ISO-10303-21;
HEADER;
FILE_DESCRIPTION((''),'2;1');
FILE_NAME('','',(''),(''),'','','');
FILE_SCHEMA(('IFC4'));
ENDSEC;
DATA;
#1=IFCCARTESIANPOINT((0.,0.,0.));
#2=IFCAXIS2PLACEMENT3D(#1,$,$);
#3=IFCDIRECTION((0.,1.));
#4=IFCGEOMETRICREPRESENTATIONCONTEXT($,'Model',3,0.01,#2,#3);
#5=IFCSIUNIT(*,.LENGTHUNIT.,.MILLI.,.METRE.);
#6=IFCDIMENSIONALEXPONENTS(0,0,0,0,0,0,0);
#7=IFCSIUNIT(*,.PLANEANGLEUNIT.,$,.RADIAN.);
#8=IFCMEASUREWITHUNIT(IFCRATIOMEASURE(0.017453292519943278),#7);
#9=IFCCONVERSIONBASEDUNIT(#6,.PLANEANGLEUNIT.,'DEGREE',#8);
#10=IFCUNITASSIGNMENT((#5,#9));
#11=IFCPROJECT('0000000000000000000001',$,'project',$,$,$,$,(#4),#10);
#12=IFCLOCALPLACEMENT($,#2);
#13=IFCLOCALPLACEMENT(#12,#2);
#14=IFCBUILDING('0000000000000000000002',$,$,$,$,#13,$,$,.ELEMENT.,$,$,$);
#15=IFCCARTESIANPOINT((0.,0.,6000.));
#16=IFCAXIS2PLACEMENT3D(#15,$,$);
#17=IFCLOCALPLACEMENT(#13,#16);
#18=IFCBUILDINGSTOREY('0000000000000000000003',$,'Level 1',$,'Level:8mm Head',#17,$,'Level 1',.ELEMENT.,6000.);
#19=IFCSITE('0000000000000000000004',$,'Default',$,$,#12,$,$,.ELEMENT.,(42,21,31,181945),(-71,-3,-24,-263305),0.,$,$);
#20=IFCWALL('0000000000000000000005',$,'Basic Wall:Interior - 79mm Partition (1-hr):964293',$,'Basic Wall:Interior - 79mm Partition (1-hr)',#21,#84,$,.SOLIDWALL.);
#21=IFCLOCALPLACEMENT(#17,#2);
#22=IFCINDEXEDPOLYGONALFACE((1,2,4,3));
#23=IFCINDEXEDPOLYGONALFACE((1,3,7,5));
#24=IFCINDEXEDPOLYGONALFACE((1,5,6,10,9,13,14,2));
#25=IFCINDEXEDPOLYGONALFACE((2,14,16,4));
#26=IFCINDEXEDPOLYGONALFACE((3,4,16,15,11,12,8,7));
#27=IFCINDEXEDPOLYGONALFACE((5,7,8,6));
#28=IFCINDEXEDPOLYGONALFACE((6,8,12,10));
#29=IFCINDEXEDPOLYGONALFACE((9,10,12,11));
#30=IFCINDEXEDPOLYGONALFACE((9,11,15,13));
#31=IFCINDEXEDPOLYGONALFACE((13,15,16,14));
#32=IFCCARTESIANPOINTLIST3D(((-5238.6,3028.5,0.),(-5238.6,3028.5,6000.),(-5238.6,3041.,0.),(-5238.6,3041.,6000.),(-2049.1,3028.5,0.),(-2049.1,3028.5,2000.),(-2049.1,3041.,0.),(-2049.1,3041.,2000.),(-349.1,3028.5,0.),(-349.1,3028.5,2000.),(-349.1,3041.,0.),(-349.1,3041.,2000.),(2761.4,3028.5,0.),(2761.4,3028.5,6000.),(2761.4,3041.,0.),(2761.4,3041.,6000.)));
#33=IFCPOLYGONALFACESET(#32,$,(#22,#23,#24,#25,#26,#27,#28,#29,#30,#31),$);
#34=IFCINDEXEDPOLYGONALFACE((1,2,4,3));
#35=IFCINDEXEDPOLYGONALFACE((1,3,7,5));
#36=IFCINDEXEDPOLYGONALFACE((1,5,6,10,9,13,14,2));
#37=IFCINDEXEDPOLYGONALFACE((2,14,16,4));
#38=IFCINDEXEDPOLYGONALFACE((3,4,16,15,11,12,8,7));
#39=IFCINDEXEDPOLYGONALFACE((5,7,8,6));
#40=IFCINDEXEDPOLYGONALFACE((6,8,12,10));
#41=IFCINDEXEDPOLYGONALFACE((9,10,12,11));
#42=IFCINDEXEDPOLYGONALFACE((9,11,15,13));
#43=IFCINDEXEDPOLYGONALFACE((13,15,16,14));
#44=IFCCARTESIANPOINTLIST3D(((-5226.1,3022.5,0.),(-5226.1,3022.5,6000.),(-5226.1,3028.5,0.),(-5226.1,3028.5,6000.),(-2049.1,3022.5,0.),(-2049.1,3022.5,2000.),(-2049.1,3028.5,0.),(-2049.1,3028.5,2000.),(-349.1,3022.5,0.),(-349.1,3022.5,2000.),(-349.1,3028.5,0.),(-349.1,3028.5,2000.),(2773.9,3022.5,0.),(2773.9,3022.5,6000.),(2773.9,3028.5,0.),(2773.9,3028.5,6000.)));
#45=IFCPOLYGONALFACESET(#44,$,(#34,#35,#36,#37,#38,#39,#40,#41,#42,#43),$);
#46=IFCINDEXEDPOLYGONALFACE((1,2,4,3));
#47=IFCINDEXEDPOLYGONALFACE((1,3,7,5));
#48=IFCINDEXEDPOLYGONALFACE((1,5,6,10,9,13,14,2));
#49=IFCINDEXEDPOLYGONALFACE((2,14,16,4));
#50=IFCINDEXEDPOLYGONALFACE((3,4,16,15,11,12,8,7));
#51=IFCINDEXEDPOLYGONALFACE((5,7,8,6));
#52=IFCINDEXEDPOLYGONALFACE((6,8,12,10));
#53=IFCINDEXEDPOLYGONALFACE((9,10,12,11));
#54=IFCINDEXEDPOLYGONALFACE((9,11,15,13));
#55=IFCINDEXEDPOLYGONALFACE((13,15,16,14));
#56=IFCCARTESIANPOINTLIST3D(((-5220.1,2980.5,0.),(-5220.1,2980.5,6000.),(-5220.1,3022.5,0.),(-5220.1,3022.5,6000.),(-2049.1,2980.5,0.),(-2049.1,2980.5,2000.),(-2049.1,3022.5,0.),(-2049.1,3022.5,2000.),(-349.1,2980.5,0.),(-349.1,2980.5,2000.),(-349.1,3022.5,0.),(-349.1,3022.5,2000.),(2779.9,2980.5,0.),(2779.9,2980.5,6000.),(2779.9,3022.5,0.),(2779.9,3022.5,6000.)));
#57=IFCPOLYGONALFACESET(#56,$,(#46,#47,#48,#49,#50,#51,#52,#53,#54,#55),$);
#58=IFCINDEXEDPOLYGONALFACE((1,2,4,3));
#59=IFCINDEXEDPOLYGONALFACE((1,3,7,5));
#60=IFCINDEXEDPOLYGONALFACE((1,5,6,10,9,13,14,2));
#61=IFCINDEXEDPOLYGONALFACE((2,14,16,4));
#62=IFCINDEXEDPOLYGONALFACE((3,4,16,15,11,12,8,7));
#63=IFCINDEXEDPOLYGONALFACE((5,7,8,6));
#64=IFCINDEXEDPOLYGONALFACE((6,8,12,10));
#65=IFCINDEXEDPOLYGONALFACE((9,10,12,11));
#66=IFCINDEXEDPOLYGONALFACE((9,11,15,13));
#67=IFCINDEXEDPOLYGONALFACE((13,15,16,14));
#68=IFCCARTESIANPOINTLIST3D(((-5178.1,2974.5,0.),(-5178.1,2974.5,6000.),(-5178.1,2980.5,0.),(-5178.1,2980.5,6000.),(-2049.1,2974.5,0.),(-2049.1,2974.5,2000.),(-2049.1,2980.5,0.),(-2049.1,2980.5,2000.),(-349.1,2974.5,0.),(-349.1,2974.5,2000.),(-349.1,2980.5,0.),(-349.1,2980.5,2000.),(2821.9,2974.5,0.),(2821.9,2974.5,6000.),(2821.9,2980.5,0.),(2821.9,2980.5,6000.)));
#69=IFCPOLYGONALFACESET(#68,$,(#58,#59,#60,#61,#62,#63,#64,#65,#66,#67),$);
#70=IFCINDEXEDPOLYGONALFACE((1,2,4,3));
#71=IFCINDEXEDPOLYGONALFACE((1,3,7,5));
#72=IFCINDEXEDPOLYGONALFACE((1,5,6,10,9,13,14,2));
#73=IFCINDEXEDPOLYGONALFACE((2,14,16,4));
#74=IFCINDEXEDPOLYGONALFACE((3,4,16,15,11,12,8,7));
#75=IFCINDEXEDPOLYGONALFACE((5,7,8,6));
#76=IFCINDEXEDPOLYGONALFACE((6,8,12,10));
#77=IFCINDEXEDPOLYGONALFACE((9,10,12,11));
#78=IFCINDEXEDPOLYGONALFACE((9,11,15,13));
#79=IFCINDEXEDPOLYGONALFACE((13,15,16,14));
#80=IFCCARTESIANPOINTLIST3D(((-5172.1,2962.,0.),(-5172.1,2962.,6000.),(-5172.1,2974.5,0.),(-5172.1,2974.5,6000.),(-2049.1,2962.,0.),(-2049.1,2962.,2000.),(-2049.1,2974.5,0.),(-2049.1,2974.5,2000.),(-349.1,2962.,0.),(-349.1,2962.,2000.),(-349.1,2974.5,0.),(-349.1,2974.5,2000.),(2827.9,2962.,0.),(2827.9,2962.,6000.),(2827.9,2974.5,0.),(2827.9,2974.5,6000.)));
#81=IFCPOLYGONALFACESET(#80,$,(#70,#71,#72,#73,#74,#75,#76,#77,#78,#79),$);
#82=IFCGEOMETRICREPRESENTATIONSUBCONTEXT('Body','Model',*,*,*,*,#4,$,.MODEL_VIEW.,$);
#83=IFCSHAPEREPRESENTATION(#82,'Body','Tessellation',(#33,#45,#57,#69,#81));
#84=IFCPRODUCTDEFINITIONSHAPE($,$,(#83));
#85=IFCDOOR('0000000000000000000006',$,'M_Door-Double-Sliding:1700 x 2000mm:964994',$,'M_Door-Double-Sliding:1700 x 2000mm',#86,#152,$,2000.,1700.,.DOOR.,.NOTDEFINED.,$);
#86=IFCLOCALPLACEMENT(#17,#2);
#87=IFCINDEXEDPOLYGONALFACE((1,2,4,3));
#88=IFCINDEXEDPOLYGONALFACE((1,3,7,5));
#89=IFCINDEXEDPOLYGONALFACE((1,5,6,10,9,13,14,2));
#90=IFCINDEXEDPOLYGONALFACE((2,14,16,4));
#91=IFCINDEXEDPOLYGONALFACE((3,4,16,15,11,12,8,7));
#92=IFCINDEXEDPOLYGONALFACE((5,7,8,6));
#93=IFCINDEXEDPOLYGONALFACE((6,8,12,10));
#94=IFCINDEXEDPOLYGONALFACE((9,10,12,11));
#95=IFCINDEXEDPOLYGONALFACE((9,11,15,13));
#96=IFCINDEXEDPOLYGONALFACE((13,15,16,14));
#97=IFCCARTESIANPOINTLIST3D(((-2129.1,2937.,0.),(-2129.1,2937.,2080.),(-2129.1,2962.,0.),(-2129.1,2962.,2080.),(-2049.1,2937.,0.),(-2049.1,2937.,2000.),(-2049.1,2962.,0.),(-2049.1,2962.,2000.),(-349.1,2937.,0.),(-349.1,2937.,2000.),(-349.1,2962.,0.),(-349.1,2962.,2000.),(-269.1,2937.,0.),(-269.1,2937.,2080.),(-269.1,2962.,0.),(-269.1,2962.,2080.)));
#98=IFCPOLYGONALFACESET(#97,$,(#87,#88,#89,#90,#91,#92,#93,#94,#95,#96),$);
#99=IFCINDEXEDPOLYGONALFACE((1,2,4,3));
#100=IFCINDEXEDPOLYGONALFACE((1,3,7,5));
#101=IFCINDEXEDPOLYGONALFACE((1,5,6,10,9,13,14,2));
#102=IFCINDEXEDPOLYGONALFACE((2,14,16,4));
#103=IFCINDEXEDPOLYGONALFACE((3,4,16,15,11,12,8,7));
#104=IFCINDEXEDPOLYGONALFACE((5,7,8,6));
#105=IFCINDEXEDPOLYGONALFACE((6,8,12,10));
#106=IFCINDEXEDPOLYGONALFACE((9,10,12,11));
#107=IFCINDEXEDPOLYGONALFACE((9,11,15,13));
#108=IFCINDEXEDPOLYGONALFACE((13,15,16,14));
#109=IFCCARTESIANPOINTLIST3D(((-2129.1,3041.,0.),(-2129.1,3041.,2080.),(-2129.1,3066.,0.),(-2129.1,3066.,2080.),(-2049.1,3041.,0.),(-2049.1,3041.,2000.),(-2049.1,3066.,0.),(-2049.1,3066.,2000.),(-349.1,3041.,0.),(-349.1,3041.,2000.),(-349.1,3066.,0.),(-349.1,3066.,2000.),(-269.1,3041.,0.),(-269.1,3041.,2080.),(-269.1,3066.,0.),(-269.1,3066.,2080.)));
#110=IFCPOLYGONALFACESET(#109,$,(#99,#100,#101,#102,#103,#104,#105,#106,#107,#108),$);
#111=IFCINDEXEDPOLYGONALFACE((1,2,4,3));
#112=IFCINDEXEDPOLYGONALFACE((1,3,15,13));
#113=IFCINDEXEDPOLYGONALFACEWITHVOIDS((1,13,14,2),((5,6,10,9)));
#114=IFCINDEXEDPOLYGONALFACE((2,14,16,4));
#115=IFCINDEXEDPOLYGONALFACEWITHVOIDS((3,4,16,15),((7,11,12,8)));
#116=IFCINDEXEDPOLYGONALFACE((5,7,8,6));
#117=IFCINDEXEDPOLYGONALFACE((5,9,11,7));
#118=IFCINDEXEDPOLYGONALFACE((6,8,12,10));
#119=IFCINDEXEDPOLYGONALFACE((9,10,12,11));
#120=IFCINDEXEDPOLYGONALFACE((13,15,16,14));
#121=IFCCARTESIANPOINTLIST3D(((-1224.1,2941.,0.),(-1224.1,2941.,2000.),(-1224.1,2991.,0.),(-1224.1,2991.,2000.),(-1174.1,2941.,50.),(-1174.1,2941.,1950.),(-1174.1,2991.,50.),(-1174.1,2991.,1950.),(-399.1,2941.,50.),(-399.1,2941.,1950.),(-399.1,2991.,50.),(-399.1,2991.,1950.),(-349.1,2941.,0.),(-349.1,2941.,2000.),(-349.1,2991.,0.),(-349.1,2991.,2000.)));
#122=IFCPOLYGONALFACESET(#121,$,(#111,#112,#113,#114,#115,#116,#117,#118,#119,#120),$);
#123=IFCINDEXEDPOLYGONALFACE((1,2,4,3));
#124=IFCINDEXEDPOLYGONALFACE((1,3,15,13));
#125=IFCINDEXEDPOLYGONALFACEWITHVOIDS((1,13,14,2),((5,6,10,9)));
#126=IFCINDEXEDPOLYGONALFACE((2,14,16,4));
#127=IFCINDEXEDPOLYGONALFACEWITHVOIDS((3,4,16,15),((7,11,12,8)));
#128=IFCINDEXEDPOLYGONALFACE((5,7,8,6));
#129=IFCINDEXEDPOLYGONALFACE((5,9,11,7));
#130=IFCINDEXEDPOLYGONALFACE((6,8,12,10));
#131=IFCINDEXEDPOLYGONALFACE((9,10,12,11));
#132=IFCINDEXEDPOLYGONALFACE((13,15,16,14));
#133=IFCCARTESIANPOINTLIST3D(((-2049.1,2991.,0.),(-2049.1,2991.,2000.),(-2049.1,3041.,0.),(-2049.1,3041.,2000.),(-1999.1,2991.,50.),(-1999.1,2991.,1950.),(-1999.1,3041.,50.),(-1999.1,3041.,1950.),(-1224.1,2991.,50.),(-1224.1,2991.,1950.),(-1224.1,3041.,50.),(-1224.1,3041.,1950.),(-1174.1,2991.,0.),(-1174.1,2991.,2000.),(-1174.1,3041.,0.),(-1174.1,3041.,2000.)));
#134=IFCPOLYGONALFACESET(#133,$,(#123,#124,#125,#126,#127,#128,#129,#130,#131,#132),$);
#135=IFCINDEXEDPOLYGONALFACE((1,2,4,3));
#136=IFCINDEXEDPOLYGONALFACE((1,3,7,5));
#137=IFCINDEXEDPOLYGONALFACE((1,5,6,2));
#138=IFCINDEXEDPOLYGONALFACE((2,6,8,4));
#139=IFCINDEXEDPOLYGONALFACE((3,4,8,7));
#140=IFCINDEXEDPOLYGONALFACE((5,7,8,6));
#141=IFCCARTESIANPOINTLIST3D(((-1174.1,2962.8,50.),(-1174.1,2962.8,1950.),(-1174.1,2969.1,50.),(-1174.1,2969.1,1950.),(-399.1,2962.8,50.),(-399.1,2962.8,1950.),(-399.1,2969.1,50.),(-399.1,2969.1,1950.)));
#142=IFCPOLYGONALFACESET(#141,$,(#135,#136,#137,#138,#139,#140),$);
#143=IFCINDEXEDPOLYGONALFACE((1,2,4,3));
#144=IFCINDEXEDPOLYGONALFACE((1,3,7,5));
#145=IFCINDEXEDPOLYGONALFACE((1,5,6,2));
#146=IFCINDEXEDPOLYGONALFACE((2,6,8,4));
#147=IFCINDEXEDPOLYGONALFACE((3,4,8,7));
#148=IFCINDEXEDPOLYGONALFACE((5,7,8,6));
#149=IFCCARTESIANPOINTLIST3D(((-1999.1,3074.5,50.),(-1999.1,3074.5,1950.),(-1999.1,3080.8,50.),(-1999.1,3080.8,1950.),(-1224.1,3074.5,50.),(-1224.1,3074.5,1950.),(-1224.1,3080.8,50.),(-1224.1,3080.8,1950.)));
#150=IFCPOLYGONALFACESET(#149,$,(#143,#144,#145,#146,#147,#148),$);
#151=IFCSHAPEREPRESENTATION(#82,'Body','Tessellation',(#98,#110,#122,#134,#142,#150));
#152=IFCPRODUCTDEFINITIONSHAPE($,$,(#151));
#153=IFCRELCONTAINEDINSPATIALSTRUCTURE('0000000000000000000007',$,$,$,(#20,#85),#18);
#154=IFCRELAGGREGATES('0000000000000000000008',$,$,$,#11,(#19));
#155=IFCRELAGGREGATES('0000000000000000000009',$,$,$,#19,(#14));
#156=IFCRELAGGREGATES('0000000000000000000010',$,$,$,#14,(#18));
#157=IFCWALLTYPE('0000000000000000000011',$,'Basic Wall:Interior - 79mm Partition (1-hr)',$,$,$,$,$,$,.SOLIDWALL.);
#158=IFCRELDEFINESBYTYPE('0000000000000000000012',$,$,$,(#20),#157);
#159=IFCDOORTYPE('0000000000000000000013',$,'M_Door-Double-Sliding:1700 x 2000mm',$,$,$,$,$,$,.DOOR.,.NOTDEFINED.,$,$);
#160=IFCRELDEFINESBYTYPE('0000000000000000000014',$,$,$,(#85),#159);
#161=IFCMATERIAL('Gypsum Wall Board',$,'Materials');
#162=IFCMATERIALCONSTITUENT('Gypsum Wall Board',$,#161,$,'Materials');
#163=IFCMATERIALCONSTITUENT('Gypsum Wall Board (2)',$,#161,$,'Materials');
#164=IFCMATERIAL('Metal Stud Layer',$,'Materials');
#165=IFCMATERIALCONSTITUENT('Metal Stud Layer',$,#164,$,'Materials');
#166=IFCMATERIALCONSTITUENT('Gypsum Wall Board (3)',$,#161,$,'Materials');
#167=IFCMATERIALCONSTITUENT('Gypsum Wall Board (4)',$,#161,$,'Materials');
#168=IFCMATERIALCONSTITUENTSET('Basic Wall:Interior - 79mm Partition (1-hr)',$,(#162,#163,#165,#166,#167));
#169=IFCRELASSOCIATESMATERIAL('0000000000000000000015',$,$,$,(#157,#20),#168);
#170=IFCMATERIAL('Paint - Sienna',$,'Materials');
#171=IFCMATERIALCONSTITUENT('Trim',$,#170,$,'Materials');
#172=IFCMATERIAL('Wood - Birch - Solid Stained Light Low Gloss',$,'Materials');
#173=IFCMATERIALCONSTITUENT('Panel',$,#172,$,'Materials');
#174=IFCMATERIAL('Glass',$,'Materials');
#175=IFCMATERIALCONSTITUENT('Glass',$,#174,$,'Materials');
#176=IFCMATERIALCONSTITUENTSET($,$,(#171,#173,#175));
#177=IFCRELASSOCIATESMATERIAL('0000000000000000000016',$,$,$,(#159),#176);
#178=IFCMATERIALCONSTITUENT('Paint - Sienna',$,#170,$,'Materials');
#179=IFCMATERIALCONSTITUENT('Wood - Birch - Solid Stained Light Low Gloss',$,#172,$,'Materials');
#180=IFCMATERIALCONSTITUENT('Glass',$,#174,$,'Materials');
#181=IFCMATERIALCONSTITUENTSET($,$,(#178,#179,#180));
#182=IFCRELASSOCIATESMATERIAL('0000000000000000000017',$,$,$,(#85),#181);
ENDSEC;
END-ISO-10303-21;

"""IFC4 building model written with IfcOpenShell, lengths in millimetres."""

from ifc_helpers import new_model, entity, si_unit, converted_unit, direction, frame, origin, place, context, subcontext, project, spatial, indexed_curve, outline, extrude, source, transform, mapped, material, constituent, constituent_set, type_object, type_shapes, element, fill, save


model = new_model("IFC4")

# Units and contexts
model_context = context("Model", 3, precision=0.01, world=origin(), true_north=direction((0.0, 1.0)))
body_context = subcontext(model_context, "Body", "Model", "MODEL_VIEW")
ifc_project = project(units=[si_unit("LENGTHUNIT", "METRE", prefix="MILLI"), converted_unit("PLANEANGLEUNIT", "DEGREE", entity("IfcRatioMeasure", 0.017453292519943278), si_unit("PLANEANGLEUNIT", "RADIAN"), dimensions=[0, 0, 0, 0, 0, 0, 0])], contexts=[model_context])

# Site, building, storey
site_placement = place(None, origin())
site = spatial("IfcSite", under=ifc_project, at=site_placement, Name="Default", CompositionType="ELEMENT", RefLatitude=(42, 21, 31, 181945), RefLongitude=(-71, -3, -24, -263305), RefElevation=0.0)
building_placement = place(site_placement, origin())
building = spatial("IfcBuilding", under=site, at=building_placement, CompositionType="ELEMENT")
storey_placement = place(building_placement, frame((0.0, 0.0, 6000.0)))
storey = spatial("IfcBuildingStorey", under=building, at=storey_placement, Name="Level 1", ObjectType="Level:8mm Head", LongName="Level 1", CompositionType="ELEMENT", Elevation=6000.0)

# Shared definitions
ifc_material_1 = material(Name="Gypsum Wall Board", Category="Materials")
ifc_constituent_1 = constituent(ifc_material_1, Name="Gypsum Wall Board", Category="Materials")
ifc_constituent_2 = constituent(ifc_material_1, Name="Gypsum Wall Board (2)", Category="Materials")
ifc_material_2 = material(Name="Metal Stud Layer", Category="Materials")
ifc_constituent_3 = constituent(ifc_material_2, Name="Metal Stud Layer", Category="Materials")
ifc_constituent_4 = constituent(ifc_material_1, Name="Gypsum Wall Board (3)", Category="Materials")
ifc_constituent_5 = constituent(ifc_material_1, Name="Gypsum Wall Board (4)", Category="Materials")
ifc_constituent_set_1 = constituent_set(constituents=[ifc_constituent_1, ifc_constituent_2, ifc_constituent_3, ifc_constituent_4, ifc_constituent_5], Name="Basic Wall:Interior - 79mm Partition (1-hr)")
wall_type = type_object("IfcWallType", Name="Basic Wall:Interior - 79mm Partition (1-hr)", PredefinedType="SOLIDWALL", material=ifc_constituent_set_1)

# Wall, opening, door
wall_1_placement = place(storey_placement, frame((2761.4, 3001.5, 0.0), z_axis=(0.0, 0.0, 1.0), x_axis=(-1.0, 0.0, 0.0)))
wall_1 = element("IfcWall", 1, at=wall_1_placement, inside=storey, type_object=wall_type, material=ifc_constituent_set_1, Name="Basic Wall:Interior - 79mm Partition (1-hr):964293", ObjectType="Basic Wall:Interior - 79mm Partition (1-hr)", PredefinedType="SOLIDWALL", context=body_context, shape_type="SweptSolid", body=[
    extrude(outline(indexed_curve([(-2000.0, -869.8), (-2000.0, -3980.3), (4000.0, -3980.3), (4000.0, 4019.8), (-2000.0, 4019.8), (-2000.0, 830.2), (0.0, 830.2), (0.0, -869.8), (-2000.0, -869.8)], self_intersect=False)), frame((3980.3, -27.0, 2000.0), z_axis=(0.0, 1.0, 0.0), x_axis=(0.0, 0.0, 1.0)), (0.0, 0.0, -1.0), 12.5),
    extrude(outline(indexed_curve([(-2000.0, -863.5), (-2000.0, -3986.5), (4000.0, -3986.5), (4000.0, 4013.5), (-2000.0, 4013.5), (-2000.0, 836.5), (0.0, 836.5), (0.0, -863.5), (-2000.0, -863.5)], self_intersect=False)), frame((3974.0, -21.0, 2000.0), z_axis=(0.0, 1.0, 0.0), x_axis=(0.0, 0.0, 1.0)), (0.0, 0.0, -1.0), 6.0),
    extrude(outline(indexed_curve([(-2000.0, -860.5), (-2000.0, -3989.5), (4000.0, -3989.5), (4000.0, 4010.5), (-2000.0, 4010.5), (-2000.0, 839.5), (0.0, 839.5), (0.0, -860.5), (-2000.0, -860.5)], self_intersect=False)), frame((3971.0, 21.0, 2000.0), z_axis=(0.0, 1.0, 0.0), x_axis=(0.0, 0.0, 1.0)), (0.0, 0.0, -1.0), 42.0),
    extrude(outline(indexed_curve([(-2000.0, -839.5), (-2000.0, -4010.5), (4000.0, -4010.5), (4000.0, 3989.5), (-2000.0, 3989.5), (-2000.0, 860.5), (0.0, 860.5), (0.0, -839.5), (-2000.0, -839.5)], self_intersect=False)), frame((3950.0, 27.0, 2000.0), z_axis=(0.0, 1.0, 0.0), x_axis=(0.0, 0.0, 1.0)), (0.0, 0.0, -1.0), 6.0),
    extrude(outline(indexed_curve([(-1631.3, 200.0), (-1631.3, 2200.0), (-4808.3, 2200.0), (-4808.3, -3800.0), (3179.2, -3800.0), (3191.7, -3800.0), (3191.7, 2200.0), (3179.2, 2200.0), (68.7, 2200.0), (68.7, 200.0), (-1631.3, 200.0)], self_intersect=False)), frame((4741.8, 39.5, 2200.0), z_axis=(0.0, 1.0, 0.0), x_axis=(1.0, 0.0, 0.0)), (0.0, 0.0, -1.0), 12.5),
])
opening_1_placement = place(wall_1_placement, frame((4810.5, 39.5, 0.0)))
opening_1 = element("IfcOpeningElement", 2, at=opening_1_placement, cuts=wall_1, PredefinedType="OPENING", context=body_context, shape_type="SweptSolid", body=[
    extrude(outline(indexed_curve([(2000.0, 0.0), (2000.0, 1700.0), (0.0, 1700.0), (0.0, 0.0), (2000.0, 0.0)], self_intersect=False)), frame((0.0, 0.0, 0.0), z_axis=(0.0, -1.0, 0.0), x_axis=(0.0, 0.0, 1.0)), (0.0, 0.0, 1.0), 79.0),
])
ifc_material_3 = material(Name="Paint - Sienna", Category="Materials")
ifc_constituent_6 = constituent(ifc_material_3, Name="Paint - Sienna", Category="Materials")
ifc_material_4 = material(Name="Wood - Birch - Solid Stained Light Low Gloss", Category="Materials")
ifc_constituent_7 = constituent(ifc_material_4, Name="Wood - Birch - Solid Stained Light Low Gloss", Category="Materials")
ifc_material_5 = material(Name="Glass", Category="Materials")
ifc_constituent_8 = constituent(ifc_material_5, Name="Glass", Category="Materials")
ifc_constituent_set_2 = constituent_set(constituents=[ifc_constituent_6, ifc_constituent_7, ifc_constituent_8])
ifc_constituent_9 = constituent(ifc_material_3, Name="Trim", Category="Materials")
ifc_constituent_10 = constituent(ifc_material_4, Name="Panel", Category="Materials")
ifc_constituent_11 = constituent(ifc_material_5, Name="Glass", Category="Materials")
ifc_constituent_set_3 = constituent_set(constituents=[ifc_constituent_9, ifc_constituent_10, ifc_constituent_11])
door_type = type_object("IfcDoorType", Name="M_Door-Double-Sliding:1700 x 2000mm", OperationType="NOTDEFINED", PredefinedType="DOOR", material=ifc_constituent_set_3)
shared_shape_1 = source(origin(), body_context, "Body", "SweptSolid", [
    extrude(outline(indexed_curve([(-1020.0, -930.0), (1060.0, -930.0), (1060.0, 930.0), (-1020.0, 930.0), (-1020.0, 850.0), (980.0, 850.0), (980.0, -850.0), (-1020.0, -850.0), (-1020.0, -930.0)], self_intersect=False)), frame((850.0, -25.0, 1020.0), z_axis=(0.0, 1.0, 0.0), x_axis=(0.0, 0.0, 1.0)), (0.0, 0.0, 1.0), 25.0),
    extrude(outline(indexed_curve([(-930.0, -1020.0), (-850.0, -1020.0), (-850.0, 980.0), (850.0, 980.0), (850.0, -1020.0), (930.0, -1020.0), (930.0, 1060.0), (-930.0, 1060.0), (-930.0, -1020.0)], self_intersect=False)), frame((850.0, 79.0, 1020.0), z_axis=(0.0, 1.0, 0.0), x_axis=(-1.0, 0.0, 0.0)), (0.0, 0.0, 1.0), 25.0),
    extrude(outline(indexed_curve([(-437.5, -1000.0), (437.5, -1000.0), (437.5, 1000.0), (-437.5, 1000.0), (-437.5, -1000.0)], self_intersect=False), holes=[indexed_curve([(-387.5, -950.0), (-387.5, 950.0), (387.5, 950.0), (387.5, -950.0), (-387.5, -950.0)], self_intersect=False)]), frame((1262.5, -21.0, 1000.0), z_axis=(0.0, 1.0, 0.0), x_axis=(1.0, 0.0, 0.0)), (0.0, 0.0, 1.0), 50.0),
    extrude(outline(indexed_curve([(-1000.0, -437.5), (1000.0, -437.5), (1000.0, 437.5), (-1000.0, 437.5), (-1000.0, -437.5)], self_intersect=False), holes=[indexed_curve([(-950.0, -387.5), (-950.0, 387.5), (950.0, 387.5), (950.0, -387.5), (-950.0, -387.5)], self_intersect=False)]), frame((437.5, 29.0, 1000.0), z_axis=(0.0, 1.0, 0.0), x_axis=(0.0, 0.0, -1.0)), (0.0, 0.0, 1.0), 50.0),
    extrude(outline(indexed_curve([(-3.2, -387.5), (3.2, -387.5), (3.2, 387.5), (-3.2, 387.5), (-3.2, -387.5)], self_intersect=False)), frame((1262.5, 4.0, 50.0), z_axis=(0.0, 0.0, 1.0), x_axis=(0.0, -1.0, 0.0)), (0.0, 0.0, 1.0), 1900.0),
    extrude(outline(indexed_curve([(-3.2, -387.5), (3.2, -387.5), (3.2, 387.5), (-3.2, 387.5), (-3.2, -387.5)], self_intersect=False)), frame((437.5, 115.7, 50.0), z_axis=(0.0, 0.0, 1.0), x_axis=(0.0, 1.0, 0.0)), (0.0, 0.0, 1.0), 1900.0),
])
type_shapes(door_type, [shared_shape_1])
door_1_placement = place(opening_1_placement, frame((0.0, 0.0, 0.0), z_axis=(0.0, 0.0, 1.0), x_axis=(-1.0, 0.0, 0.0)))
door_1 = element("IfcDoor", 3, at=door_1_placement, inside=storey, type_object=door_type, material=ifc_constituent_set_2, Name="M_Door-Double-Sliding:1700 x 2000mm:964994", ObjectType="M_Door-Double-Sliding:1700 x 2000mm", OperationType="NOTDEFINED", OverallHeight=2000.0, OverallWidth=1700.0, PredefinedType="DOOR", context=body_context, shape_type="MappedRepresentation", body=[
    mapped(shared_shape_1, transform((0.0, 0.0, 0.0), scale=1.0)),
])
fill(opening_1, door_1)

save(model, "model.ifc")
